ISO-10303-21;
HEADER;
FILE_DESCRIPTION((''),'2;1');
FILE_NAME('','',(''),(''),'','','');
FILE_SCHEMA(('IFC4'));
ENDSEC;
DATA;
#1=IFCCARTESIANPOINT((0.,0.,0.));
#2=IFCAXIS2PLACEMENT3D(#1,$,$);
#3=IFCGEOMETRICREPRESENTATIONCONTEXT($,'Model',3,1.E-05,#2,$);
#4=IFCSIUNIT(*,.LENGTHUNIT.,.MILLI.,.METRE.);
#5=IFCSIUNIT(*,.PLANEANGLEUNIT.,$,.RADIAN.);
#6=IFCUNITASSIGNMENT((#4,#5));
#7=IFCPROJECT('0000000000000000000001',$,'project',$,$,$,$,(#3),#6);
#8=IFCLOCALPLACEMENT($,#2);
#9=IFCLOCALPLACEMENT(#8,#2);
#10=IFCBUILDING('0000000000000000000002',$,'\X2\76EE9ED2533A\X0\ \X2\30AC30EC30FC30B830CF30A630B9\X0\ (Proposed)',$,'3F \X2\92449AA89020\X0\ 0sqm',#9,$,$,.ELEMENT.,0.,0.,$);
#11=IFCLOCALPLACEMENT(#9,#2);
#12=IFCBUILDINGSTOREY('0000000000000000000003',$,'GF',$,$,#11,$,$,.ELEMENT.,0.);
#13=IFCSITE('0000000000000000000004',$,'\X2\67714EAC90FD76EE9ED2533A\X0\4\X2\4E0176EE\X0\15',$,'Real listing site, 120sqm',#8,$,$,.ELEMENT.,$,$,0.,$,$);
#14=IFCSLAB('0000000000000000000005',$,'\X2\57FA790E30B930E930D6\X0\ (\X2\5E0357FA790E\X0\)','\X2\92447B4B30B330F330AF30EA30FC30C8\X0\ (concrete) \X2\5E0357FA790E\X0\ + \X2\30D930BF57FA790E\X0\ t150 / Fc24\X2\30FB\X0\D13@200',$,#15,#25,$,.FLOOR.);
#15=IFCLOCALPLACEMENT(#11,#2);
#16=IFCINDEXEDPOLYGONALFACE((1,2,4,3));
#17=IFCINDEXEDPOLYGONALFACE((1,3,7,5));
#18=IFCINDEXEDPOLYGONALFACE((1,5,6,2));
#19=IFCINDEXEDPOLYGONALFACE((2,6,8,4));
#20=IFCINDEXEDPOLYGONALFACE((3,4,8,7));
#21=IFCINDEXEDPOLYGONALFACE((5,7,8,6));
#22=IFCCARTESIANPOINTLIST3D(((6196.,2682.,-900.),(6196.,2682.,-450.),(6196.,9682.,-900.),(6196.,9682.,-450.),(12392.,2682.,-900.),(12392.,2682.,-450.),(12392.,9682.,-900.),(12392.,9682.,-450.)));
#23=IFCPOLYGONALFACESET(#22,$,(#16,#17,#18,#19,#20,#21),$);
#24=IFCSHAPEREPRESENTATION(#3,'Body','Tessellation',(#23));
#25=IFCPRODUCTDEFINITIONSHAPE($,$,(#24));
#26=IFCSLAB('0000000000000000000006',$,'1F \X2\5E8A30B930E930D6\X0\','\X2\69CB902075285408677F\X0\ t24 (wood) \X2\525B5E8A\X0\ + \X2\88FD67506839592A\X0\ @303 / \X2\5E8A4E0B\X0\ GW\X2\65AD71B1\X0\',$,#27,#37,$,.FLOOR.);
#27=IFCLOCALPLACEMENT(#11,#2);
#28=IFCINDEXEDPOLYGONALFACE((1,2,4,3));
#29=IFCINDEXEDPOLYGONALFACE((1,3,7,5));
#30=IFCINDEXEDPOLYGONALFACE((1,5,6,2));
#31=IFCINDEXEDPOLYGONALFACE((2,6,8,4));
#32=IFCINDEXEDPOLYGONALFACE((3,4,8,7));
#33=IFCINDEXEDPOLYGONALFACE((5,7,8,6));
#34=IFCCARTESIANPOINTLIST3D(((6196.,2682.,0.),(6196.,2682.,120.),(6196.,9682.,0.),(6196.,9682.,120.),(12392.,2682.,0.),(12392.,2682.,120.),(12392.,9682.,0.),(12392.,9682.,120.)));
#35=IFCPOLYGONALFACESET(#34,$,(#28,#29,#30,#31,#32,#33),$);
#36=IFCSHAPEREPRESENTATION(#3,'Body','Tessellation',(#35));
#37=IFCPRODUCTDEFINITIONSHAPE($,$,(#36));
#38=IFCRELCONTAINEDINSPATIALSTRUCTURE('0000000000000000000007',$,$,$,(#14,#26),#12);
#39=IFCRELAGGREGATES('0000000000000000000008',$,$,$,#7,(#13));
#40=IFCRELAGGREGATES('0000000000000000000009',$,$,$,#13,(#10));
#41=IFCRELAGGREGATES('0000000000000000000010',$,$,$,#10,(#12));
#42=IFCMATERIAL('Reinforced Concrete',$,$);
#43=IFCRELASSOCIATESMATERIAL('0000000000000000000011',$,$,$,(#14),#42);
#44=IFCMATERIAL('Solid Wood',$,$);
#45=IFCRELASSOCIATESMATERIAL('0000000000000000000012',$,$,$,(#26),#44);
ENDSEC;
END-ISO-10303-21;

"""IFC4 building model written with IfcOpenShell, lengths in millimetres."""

from ifc_helpers import new_model, si_unit, frame, frame_2d, origin, place, context, project, spatial, rectangle, extrude, material, element, save


model = new_model("IFC4")

# Units and contexts
model_context = context("Model", 3, precision=1e-05, world=origin())
ifc_project = project(units=[si_unit("LENGTHUNIT", "METRE", prefix="MILLI"), si_unit("PLANEANGLEUNIT", "RADIAN")], contexts=[model_context])

# Site, building, storey
site_placement = place(None, origin())
site = spatial("IfcSite", under=ifc_project, at=site_placement, Name="東京都目黒区4丁目15", ObjectType="Real listing site, 120sqm", CompositionType="ELEMENT", RefElevation=0.0)
building_placement = place(site_placement, origin())
building = spatial("IfcBuilding", under=site, at=building_placement, Name="目黒区 ガレージハウス (Proposed)", ObjectType="3F 鉄骨造 0sqm", CompositionType="ELEMENT", ElevationOfRefHeight=0.0, ElevationOfTerrain=0.0)
storey_placement = place(building_placement, origin())
storey = spatial("IfcBuildingStorey", under=building, at=storey_placement, Name="GF", CompositionType="ELEMENT", Elevation=0.0)

# Slabs
ifc_material_1 = material(Name="Reinforced Concrete")
slab_1_placement = place(storey_placement, frame((3098.0, 1341.0, -450.0)))
element("IfcSlab", 1, at=slab_1_placement, inside=storey, material=ifc_material_1, Name="基礎スラブ (布基礎)", Description="鉄筋コンクリート (concrete) 布基礎 + ベタ基礎 t150 / Fc24・D13@200", PredefinedType="FLOOR", context=model_context, shape_type="SweptSolid", body=[
    extrude(rectangle(XDim=6196.0, YDim=7000.0, at=frame_2d((3098.0, 3500.0))), frame((3098.0, 1341.0, -450.0)), (0.0, 0.0, 1.0), 450.0),
])
ifc_material_2 = material(Name="Solid Wood")
slab_2_placement = place(storey_placement, frame((3098.0, 1341.0, 0.0)))
element("IfcSlab", 2, at=slab_2_placement, inside=storey, material=ifc_material_2, Name="1F 床スラブ", Description="構造用合板 t24 (wood) 剛床 + 製材根太 @303 / 床下 GW断熱", PredefinedType="FLOOR", context=model_context, shape_type="SweptSolid", body=[
    extrude(rectangle(XDim=6196.0, YDim=7000.0, at=frame_2d((3098.0, 3500.0))), frame((3098.0, 1341.0, 0.0)), (0.0, 0.0, 1.0), 120.0),
])

save(model, "model.ifc")
